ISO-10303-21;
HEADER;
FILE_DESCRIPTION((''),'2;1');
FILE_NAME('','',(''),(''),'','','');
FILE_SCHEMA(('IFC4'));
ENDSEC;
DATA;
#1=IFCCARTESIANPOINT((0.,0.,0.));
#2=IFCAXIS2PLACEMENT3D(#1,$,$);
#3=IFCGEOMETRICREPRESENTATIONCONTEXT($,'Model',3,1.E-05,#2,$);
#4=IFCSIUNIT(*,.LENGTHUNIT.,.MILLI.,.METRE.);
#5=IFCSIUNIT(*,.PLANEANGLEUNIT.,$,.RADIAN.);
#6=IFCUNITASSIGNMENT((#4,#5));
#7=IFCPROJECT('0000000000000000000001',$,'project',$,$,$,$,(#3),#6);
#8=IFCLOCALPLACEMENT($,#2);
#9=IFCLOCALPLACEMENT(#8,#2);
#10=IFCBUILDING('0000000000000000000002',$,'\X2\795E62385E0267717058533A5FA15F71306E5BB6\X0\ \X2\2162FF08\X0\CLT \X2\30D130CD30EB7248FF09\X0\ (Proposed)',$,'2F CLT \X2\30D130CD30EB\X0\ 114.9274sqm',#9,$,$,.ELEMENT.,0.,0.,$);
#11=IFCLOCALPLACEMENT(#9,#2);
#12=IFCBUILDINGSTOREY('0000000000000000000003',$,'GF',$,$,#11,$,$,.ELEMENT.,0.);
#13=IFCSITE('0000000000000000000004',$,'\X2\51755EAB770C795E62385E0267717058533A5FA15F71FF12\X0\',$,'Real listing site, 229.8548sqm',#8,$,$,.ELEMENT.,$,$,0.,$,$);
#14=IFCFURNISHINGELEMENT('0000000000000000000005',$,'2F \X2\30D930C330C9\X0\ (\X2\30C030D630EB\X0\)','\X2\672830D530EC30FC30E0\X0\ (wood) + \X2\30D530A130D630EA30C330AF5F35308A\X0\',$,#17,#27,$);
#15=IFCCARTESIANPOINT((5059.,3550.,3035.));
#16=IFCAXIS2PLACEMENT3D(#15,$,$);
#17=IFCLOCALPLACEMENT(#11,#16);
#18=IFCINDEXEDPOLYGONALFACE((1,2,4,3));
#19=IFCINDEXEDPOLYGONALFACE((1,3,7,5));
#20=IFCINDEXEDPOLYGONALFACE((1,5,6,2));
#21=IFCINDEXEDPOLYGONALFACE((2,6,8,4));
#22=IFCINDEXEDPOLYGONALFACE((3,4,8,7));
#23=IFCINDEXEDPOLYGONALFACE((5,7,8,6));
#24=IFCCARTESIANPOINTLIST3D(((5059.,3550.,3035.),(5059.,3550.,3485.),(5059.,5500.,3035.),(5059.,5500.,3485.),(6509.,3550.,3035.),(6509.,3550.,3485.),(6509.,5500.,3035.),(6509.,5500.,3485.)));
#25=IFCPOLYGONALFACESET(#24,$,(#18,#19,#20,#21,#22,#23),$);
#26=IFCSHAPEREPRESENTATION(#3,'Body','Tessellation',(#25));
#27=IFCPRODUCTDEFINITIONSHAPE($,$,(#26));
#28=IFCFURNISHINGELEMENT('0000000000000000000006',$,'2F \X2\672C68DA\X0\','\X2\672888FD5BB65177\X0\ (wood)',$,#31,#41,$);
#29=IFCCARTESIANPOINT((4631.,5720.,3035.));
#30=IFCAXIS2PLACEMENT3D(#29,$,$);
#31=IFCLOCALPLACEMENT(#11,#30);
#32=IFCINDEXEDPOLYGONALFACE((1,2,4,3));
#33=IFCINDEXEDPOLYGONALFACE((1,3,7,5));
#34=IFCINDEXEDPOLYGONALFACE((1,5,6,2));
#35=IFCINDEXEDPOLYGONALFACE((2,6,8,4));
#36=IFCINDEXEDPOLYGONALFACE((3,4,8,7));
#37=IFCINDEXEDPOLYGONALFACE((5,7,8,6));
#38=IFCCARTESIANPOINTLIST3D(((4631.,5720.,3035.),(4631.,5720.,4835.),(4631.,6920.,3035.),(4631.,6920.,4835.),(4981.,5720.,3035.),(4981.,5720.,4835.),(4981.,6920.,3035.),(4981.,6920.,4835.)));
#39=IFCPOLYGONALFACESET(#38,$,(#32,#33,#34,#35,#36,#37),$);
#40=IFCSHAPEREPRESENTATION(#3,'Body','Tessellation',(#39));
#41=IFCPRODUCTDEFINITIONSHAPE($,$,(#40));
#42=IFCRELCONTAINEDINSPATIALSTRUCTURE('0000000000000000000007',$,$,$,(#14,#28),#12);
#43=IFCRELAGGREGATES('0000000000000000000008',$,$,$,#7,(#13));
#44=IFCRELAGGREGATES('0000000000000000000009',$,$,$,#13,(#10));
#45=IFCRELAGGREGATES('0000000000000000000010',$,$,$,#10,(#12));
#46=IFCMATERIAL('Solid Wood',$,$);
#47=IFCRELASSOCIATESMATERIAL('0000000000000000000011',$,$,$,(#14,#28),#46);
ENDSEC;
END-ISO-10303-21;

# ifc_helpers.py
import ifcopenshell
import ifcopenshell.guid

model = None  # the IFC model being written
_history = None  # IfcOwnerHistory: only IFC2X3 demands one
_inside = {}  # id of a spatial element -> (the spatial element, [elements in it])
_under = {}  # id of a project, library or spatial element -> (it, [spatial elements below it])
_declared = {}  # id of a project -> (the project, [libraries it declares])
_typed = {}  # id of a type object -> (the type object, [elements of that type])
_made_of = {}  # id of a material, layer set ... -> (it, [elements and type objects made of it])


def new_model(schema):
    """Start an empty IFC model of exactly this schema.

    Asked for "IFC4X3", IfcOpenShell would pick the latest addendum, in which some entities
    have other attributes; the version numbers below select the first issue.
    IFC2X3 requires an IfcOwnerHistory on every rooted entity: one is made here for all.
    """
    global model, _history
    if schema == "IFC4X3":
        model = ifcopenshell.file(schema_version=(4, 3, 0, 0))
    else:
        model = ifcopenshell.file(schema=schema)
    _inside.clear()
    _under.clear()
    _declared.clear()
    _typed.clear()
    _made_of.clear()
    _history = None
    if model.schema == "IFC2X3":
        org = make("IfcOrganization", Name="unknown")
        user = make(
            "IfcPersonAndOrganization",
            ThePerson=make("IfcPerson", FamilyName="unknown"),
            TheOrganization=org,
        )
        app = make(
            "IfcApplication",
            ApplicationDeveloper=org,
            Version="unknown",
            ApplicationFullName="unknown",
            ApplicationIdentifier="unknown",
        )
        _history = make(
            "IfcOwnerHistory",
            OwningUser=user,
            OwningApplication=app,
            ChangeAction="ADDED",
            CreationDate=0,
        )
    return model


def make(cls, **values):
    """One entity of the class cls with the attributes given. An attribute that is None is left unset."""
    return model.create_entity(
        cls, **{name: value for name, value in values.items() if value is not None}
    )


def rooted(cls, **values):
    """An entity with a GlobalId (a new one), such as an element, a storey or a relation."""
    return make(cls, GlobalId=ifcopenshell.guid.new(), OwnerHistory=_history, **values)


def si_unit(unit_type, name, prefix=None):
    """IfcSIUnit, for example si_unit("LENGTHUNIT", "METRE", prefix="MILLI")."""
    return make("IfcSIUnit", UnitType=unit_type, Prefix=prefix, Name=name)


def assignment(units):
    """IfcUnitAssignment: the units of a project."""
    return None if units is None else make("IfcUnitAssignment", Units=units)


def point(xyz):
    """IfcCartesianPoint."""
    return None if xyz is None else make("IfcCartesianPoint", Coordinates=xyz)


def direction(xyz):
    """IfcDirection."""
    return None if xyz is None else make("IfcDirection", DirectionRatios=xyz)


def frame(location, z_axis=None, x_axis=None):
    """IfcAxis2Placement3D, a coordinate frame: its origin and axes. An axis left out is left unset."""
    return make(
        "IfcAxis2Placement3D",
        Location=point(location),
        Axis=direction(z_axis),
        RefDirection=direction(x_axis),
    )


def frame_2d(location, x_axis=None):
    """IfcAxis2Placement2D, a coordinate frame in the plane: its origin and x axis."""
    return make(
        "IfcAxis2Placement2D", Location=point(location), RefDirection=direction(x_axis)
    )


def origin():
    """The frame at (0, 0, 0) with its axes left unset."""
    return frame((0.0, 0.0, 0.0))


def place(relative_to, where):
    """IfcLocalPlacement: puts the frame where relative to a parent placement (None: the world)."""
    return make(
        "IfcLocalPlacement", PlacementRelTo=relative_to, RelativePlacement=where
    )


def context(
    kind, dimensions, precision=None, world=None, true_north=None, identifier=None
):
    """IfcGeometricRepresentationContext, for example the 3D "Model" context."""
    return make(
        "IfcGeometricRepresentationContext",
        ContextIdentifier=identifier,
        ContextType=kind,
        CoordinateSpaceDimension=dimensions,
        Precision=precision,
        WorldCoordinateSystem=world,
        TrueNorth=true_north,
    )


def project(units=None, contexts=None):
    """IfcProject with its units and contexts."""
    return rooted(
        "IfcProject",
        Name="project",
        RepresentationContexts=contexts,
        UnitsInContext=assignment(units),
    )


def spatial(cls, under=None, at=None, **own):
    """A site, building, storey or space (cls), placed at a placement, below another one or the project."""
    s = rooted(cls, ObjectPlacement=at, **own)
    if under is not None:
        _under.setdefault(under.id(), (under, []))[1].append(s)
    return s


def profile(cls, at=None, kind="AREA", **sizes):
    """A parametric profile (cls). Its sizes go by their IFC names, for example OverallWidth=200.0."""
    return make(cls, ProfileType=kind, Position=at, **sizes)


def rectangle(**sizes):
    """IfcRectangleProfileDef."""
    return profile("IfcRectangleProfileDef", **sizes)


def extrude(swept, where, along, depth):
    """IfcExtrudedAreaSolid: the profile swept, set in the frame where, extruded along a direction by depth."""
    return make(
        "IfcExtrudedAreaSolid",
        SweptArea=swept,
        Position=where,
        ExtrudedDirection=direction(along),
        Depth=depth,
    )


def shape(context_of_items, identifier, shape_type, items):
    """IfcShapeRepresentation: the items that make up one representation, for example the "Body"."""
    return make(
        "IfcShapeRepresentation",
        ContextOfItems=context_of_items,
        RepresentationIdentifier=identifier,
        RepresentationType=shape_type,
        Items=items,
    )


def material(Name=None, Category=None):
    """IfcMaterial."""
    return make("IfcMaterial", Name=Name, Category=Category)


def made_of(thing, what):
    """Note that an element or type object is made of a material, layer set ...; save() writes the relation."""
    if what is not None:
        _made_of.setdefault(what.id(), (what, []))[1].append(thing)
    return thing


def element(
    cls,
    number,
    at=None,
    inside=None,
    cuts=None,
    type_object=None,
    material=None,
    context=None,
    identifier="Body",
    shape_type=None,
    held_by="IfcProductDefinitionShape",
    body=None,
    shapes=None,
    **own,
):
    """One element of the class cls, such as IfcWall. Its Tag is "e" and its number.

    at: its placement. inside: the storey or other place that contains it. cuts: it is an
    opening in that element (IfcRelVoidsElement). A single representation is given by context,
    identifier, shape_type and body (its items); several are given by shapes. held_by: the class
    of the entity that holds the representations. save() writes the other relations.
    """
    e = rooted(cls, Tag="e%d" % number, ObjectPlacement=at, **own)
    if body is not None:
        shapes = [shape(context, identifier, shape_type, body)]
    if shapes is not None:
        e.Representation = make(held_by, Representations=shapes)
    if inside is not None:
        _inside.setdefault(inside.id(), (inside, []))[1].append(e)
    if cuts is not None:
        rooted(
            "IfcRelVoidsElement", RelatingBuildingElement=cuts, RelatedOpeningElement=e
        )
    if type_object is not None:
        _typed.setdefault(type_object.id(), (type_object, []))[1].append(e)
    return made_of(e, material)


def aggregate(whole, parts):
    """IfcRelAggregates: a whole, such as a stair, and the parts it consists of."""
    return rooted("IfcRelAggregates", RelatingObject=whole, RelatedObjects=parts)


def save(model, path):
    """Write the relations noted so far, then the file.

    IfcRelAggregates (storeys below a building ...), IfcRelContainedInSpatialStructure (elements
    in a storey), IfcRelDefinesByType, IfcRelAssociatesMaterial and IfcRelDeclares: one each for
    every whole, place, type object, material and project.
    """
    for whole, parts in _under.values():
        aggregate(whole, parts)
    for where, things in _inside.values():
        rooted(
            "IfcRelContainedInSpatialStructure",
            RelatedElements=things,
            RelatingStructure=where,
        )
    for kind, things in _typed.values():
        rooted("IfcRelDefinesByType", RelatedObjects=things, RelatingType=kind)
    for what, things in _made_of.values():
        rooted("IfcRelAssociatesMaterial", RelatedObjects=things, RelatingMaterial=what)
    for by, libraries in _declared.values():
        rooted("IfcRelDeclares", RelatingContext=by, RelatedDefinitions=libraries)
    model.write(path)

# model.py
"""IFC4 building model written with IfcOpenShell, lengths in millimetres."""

from ifc_helpers import new_model, si_unit, frame, frame_2d, origin, place, context, project, spatial, rectangle, extrude, material, element, save


model = new_model("IFC4")

# Units and contexts
model_context = context("Model", 3, precision=1e-05, world=origin())
ifc_project = project(units=[si_unit("LENGTHUNIT", "METRE", prefix="MILLI"), si_unit("PLANEANGLEUNIT", "RADIAN")], contexts=[model_context])

# Site, building, storey
site_placement = place(None, origin())
site = spatial("IfcSite", under=ifc_project, at=site_placement, Name="兵庫県神戸市東灘区御影２", ObjectType="Real listing site, 229.8548sqm", CompositionType="ELEMENT", RefElevation=0.0)
building_placement = place(site_placement, origin())
building = spatial("IfcBuilding", under=site, at=building_placement, Name="神戸市東灘区御影の家 Ⅲ（CLT パネル版） (Proposed)", ObjectType="2F CLT パネル 114.9274sqm", CompositionType="ELEMENT", ElevationOfRefHeight=0.0, ElevationOfTerrain=0.0)
storey_placement = place(building_placement, origin())
storey = spatial("IfcBuildingStorey", under=building, at=storey_placement, Name="GF", CompositionType="ELEMENT", Elevation=0.0)

# Shared definitions
ifc_material_1 = material(Name="Solid Wood")

# Furnishing elements
furnishing_1_placement = place(storey_placement, frame((5059.0, 3550.0, 3035.0)))
element("IfcFurnishingElement", 1, at=furnishing_1_placement, inside=storey, material=ifc_material_1, Name="2F ベッド (ダブル)", Description="木フレーム (wood) + ファブリック張り", context=model_context, shape_type="SweptSolid", body=[
    extrude(rectangle(XDim=1450.0, YDim=1950.0, at=frame_2d((725.0, 975.0))), frame((5059.0, 3550.0, 3035.0)), (0.0, 0.0, 1.0), 450.0),
])
furnishing_2_placement = place(storey_placement, frame((4631.0, 5720.0, 3035.0)))
element("IfcFurnishingElement", 2, at=furnishing_2_placement, inside=storey, material=ifc_material_1, Name="2F 本棚", Description="木製家具 (wood)", context=model_context, shape_type="SweptSolid", body=[
    extrude(rectangle(XDim=350.0, YDim=1200.0, at=frame_2d((175.0, 600.0))), frame((4631.0, 5720.0, 3035.0)), (0.0, 0.0, 1.0), 1800.0),
])

save(model, "model.ifc")
